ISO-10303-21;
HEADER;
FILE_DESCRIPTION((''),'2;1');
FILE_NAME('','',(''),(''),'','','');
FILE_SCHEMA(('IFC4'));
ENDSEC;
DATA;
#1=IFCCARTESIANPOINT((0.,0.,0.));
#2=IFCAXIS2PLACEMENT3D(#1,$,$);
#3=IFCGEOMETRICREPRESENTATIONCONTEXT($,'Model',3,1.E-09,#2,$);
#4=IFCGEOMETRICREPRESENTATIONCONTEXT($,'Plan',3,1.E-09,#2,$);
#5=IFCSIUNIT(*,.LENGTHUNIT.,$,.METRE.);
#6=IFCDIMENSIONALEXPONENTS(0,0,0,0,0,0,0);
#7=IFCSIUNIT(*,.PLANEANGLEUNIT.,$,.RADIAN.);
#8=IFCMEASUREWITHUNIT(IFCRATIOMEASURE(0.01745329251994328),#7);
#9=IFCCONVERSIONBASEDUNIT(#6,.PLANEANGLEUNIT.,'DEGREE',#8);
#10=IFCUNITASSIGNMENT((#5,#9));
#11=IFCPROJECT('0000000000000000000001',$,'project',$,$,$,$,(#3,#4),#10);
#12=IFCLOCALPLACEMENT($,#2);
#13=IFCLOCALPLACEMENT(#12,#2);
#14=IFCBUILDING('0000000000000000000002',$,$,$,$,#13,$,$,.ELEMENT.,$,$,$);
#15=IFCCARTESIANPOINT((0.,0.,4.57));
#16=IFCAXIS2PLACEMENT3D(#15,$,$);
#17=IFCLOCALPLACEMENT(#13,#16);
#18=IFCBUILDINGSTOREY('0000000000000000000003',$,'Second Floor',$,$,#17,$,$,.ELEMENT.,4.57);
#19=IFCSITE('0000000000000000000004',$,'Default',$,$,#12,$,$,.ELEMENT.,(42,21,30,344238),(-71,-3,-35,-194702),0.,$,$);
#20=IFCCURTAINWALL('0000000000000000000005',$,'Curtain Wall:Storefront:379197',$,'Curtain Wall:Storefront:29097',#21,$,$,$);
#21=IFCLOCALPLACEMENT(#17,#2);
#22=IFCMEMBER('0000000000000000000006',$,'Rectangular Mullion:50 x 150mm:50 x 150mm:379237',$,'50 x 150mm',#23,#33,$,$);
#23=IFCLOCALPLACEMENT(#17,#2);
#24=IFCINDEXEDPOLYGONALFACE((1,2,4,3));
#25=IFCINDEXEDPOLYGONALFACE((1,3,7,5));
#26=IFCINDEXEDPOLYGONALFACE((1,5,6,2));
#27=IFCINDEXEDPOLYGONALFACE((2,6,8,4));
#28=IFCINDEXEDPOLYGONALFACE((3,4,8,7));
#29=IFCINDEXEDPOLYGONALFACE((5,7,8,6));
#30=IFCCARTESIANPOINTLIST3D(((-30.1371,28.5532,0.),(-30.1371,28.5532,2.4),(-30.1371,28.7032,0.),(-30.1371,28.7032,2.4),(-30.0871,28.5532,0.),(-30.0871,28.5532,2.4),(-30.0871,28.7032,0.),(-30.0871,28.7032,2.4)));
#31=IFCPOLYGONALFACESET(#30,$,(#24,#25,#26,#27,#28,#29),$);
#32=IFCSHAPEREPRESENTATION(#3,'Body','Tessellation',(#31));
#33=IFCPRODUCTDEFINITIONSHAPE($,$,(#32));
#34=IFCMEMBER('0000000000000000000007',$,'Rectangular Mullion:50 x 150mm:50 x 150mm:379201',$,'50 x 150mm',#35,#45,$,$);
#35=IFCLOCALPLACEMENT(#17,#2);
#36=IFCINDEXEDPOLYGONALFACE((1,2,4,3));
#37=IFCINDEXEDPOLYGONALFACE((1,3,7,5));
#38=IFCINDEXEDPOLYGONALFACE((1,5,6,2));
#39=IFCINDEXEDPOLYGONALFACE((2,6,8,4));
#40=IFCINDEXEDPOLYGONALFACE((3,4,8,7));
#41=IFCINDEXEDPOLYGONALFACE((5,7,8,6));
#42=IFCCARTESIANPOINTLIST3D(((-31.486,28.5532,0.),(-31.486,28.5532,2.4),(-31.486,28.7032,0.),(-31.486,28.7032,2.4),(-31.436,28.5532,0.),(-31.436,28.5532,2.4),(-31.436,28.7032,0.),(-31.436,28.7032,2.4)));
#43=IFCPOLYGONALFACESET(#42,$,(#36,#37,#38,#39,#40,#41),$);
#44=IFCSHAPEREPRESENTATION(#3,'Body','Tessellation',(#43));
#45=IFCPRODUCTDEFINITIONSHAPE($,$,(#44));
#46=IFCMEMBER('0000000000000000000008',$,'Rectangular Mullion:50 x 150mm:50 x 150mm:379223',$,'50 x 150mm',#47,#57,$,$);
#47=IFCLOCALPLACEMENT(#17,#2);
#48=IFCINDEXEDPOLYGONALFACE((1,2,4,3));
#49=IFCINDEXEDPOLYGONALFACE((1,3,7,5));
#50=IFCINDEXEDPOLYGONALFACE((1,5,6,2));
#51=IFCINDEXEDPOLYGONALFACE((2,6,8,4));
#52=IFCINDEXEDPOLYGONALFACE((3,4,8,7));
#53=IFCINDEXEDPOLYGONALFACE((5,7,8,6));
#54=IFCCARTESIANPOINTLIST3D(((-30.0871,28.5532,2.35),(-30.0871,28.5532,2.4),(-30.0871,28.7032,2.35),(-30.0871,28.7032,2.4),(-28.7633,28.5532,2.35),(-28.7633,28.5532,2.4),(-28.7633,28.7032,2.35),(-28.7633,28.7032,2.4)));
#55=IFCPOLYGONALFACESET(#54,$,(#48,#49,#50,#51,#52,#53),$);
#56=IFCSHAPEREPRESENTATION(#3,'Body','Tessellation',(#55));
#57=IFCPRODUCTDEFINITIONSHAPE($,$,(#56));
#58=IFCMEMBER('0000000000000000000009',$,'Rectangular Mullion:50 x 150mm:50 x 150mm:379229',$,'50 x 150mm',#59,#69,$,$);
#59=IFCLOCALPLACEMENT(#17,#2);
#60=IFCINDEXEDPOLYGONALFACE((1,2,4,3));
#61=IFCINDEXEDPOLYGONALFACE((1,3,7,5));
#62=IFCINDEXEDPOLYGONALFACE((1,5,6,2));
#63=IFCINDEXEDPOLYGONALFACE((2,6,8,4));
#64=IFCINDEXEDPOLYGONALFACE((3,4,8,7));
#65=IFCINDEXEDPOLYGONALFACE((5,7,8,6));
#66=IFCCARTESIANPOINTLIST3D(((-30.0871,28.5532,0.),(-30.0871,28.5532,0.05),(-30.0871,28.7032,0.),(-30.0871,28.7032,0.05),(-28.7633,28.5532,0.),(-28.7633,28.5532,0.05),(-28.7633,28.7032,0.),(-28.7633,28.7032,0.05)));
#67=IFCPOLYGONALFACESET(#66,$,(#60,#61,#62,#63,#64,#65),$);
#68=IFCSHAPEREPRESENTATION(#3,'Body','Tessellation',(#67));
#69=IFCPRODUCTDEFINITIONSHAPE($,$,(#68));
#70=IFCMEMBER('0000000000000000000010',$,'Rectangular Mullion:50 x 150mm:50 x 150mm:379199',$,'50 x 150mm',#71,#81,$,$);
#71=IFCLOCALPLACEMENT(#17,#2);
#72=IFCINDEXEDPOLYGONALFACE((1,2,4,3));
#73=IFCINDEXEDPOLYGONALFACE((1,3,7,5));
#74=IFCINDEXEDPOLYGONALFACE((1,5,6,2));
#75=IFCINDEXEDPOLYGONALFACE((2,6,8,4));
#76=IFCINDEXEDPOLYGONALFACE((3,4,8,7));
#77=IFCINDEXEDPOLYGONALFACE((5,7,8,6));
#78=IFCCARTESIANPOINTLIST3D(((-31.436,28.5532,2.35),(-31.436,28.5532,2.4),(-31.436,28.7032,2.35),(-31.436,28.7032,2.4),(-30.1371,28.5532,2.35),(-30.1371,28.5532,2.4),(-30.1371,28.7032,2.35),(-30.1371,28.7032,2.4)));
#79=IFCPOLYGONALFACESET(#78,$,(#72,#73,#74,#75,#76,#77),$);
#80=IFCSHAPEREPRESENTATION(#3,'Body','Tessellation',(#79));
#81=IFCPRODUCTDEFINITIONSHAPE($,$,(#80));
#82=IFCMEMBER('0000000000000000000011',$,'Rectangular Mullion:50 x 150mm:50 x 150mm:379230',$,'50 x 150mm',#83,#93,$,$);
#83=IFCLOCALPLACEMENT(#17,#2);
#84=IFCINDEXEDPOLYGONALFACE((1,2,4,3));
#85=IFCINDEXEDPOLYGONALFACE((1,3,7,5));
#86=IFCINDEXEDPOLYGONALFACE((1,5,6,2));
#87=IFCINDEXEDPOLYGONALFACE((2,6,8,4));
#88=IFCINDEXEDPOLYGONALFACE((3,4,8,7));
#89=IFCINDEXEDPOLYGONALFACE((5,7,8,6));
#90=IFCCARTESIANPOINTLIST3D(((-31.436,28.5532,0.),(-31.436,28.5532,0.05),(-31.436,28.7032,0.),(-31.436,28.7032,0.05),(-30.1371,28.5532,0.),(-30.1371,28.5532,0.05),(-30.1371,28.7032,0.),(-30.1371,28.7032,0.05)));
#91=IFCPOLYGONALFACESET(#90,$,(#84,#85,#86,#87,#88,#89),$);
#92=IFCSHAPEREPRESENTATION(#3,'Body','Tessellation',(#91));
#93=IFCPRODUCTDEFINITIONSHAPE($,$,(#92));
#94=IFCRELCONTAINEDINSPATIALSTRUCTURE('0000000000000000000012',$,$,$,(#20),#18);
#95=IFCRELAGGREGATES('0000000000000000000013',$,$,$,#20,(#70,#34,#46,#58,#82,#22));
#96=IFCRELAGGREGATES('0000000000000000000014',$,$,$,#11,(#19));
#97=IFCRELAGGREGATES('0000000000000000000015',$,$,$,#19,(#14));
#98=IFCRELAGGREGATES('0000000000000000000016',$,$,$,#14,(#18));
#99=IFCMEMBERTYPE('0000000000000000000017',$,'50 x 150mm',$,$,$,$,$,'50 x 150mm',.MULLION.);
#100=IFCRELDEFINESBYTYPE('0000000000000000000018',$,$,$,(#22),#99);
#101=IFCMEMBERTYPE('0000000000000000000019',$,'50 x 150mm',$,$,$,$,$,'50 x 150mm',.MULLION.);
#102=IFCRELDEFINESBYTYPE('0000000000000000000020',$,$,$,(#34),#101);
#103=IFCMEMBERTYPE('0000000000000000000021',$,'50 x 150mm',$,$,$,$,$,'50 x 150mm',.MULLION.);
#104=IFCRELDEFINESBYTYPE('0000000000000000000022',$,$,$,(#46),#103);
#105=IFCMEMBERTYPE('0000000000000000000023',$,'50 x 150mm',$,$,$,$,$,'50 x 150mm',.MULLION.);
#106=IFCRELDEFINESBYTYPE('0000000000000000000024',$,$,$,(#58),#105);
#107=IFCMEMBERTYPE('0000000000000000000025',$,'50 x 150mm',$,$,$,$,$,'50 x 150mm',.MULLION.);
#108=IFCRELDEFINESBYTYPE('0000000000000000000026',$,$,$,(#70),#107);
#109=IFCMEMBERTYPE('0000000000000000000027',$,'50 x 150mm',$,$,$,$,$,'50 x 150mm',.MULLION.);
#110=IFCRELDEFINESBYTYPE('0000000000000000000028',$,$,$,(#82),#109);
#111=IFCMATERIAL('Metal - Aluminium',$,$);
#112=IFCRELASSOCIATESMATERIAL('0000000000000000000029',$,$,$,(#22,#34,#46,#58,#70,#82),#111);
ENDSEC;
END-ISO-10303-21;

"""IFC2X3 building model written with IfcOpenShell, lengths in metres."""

from ifc_helpers import new_model, entity, si_unit, converted_unit, frame, origin, origin_2d_with_axis, place, context, project, spatial, rectangle, extrude, source, transform, mapped, material, type_object, type_shapes, element, aggregate, save


model = new_model("IFC2X3")

# Units and contexts
model_context = context("Model", 3, precision=1e-09, world=origin())
plan_context = context("Plan", 3, precision=1e-09, world=origin())
ifc_project = project(units=[si_unit("LENGTHUNIT", "METRE"), converted_unit("PLANEANGLEUNIT", "DEGREE", entity("IfcRatioMeasure", 0.01745329251994328), si_unit("PLANEANGLEUNIT", "RADIAN"), dimensions=[0, 0, 0, 0, 0, 0, 0])], contexts=[model_context, plan_context])

# Site, building, storey
site_placement = place(None, origin())
site = spatial("IfcSite", under=ifc_project, at=site_placement, Name="Default", CompositionType="ELEMENT", RefLatitude=(42, 21, 30, 344238), RefLongitude=(-71, -3, -35, -194702), RefElevation=0.0)
building_placement = place(site_placement, origin())
building = spatial("IfcBuilding", under=site, at=building_placement, CompositionType="ELEMENT")
storey_placement = place(building_placement, frame((0.0, 0.0, 4.57)))
storey = spatial("IfcBuildingStorey", under=building, at=storey_placement, Name="Second Floor", CompositionType="ELEMENT", Elevation=4.57)

# Curtain wall, members
curtain_wall_placement = place(storey_placement, origin())
curtain_wall = element("IfcCurtainWall", 1, at=curtain_wall_placement, inside=storey, Name="Curtain Wall:Storefront:379197", ObjectType="Curtain Wall:Storefront:29097")
ifc_material_1 = material(Name="Metal - Aluminium")
member_type_1 = type_object("IfcMemberType", Name="50 x 150mm", ElementType="50 x 150mm", PredefinedType="MULLION")
shared_shape_1 = source(origin(), model_context, "Body", "SweptSolid", [
    extrude(rectangle(XDim=0.05, YDim=0.15, at=origin_2d_with_axis()), frame((0.0, 0.0, -2.4), z_axis=(0.0, 0.0, 1.0), x_axis=(-1.0, 0.0, 0.0)), (0.0, 0.0, 1.0), 2.4),
])
type_shapes(member_type_1, [shared_shape_1])
member_1_placement = place(storey_placement, frame((-30.1121, 28.6282, 0.0), z_axis=(0.0, 0.0, -1.0), x_axis=(-1.0, 0.0, 0.0)))
member_1 = element("IfcMember", 2, at=member_1_placement, type_object=member_type_1, material=ifc_material_1, Name="Rectangular Mullion:50 x 150mm:50 x 150mm:379237", ObjectType="50 x 150mm", context=model_context, shape_type="MappedRepresentation", body=[
    mapped(shared_shape_1, transform((0.0, 0.0, 0.0), scale=1.0)),
])
member_type_2 = type_object("IfcMemberType", Name="50 x 150mm", ElementType="50 x 150mm", PredefinedType="MULLION")
shared_shape_2 = source(origin(), model_context, "Body", "SweptSolid", [
    extrude(rectangle(XDim=0.05, YDim=0.15, at=origin_2d_with_axis()), frame((-0.025, 0.0, -2.4), z_axis=(0.0, 0.0, 1.0), x_axis=(-1.0, 0.0, 0.0)), (0.0, 0.0, 1.0), 2.4),
])
type_shapes(member_type_2, [shared_shape_2])
member_2_placement = place(storey_placement, frame((-31.486, 28.6282, 0.0), z_axis=(0.0, 0.0, -1.0), x_axis=(-1.0, 0.0, 0.0)))
member_2 = element("IfcMember", 3, at=member_2_placement, type_object=member_type_2, material=ifc_material_1, Name="Rectangular Mullion:50 x 150mm:50 x 150mm:379201", ObjectType="50 x 150mm", context=model_context, shape_type="MappedRepresentation", body=[
    mapped(shared_shape_2, transform((0.0, 0.0, 0.0), scale=1.0)),
])
member_type_3 = type_object("IfcMemberType", Name="50 x 150mm", ElementType="50 x 150mm", PredefinedType="MULLION")
shared_shape_3 = source(origin(), model_context, "Body", "SweptSolid", [
    extrude(rectangle(XDim=0.05, YDim=0.15, at=origin_2d_with_axis()), frame((-0.025, 0.0, -1.3239), z_axis=(0.0, 0.0, 1.0), x_axis=(-1.0, 0.0, 0.0)), (0.0, 0.0, 1.0), 1.3239),
])
type_shapes(member_type_3, [shared_shape_3])
member_3_placement = place(storey_placement, frame((-30.0871, 28.6282, 2.4), z_axis=(-1.0, 0.0, 0.0), x_axis=(0.0, 0.0, 1.0)))
member_3 = element("IfcMember", 4, at=member_3_placement, type_object=member_type_3, material=ifc_material_1, Name="Rectangular Mullion:50 x 150mm:50 x 150mm:379223", ObjectType="50 x 150mm", context=model_context, shape_type="MappedRepresentation", body=[
    mapped(shared_shape_3, transform((0.0, 0.0, 0.0), scale=1.0)),
])
member_type_4 = type_object("IfcMemberType", Name="50 x 150mm", ElementType="50 x 150mm", PredefinedType="MULLION")
shared_shape_4 = source(origin(), model_context, "Body", "SweptSolid", [
    extrude(rectangle(XDim=0.05, YDim=0.15, at=origin_2d_with_axis()), frame((-0.025, 0.0, -1.3239), z_axis=(0.0, 0.0, 1.0), x_axis=(-1.0, 0.0, 0.0)), (0.0, 0.0, 1.0), 1.3239),
])
type_shapes(member_type_4, [shared_shape_4])
member_4_placement = place(storey_placement, frame((-28.7633, 28.6282, 0.0), z_axis=(1.0, 0.0, 0.0), x_axis=(0.0, 0.0, -1.0)))
member_4 = element("IfcMember", 5, at=member_4_placement, type_object=member_type_4, material=ifc_material_1, Name="Rectangular Mullion:50 x 150mm:50 x 150mm:379229", ObjectType="50 x 150mm", context=model_context, shape_type="MappedRepresentation", body=[
    mapped(shared_shape_4, transform((0.0, 0.0, 0.0), scale=1.0)),
])
member_type_5 = type_object("IfcMemberType", Name="50 x 150mm", ElementType="50 x 150mm", PredefinedType="MULLION")
shared_shape_5 = source(origin(), model_context, "Body", "SweptSolid", [
    extrude(rectangle(XDim=0.05, YDim=0.15, at=origin_2d_with_axis()), frame((-0.025, 0.0, -1.2989), z_axis=(0.0, 0.0, 1.0), x_axis=(-1.0, 0.0, 0.0)), (0.0, 0.0, 1.0), 1.2989),
])
type_shapes(member_type_5, [shared_shape_5])
member_5_placement = place(storey_placement, frame((-31.436, 28.6282, 2.4), z_axis=(-1.0, 0.0, 0.0), x_axis=(0.0, 0.0, 1.0)))
member_5 = element("IfcMember", 6, at=member_5_placement, type_object=member_type_5, material=ifc_material_1, Name="Rectangular Mullion:50 x 150mm:50 x 150mm:379199", ObjectType="50 x 150mm", context=model_context, shape_type="MappedRepresentation", body=[
    mapped(shared_shape_5, transform((0.0, 0.0, 0.0), scale=1.0)),
])
member_type_6 = type_object("IfcMemberType", Name="50 x 150mm", ElementType="50 x 150mm", PredefinedType="MULLION")
shared_shape_6 = source(origin(), model_context, "Body", "SweptSolid", [
    extrude(rectangle(XDim=0.05, YDim=0.15, at=origin_2d_with_axis()), frame((-0.025, 0.0, -1.2989), z_axis=(0.0, 0.0, 1.0), x_axis=(-1.0, 0.0, 0.0)), (0.0, 0.0, 1.0), 1.2989),
])
type_shapes(member_type_6, [shared_shape_6])
member_6_placement = place(storey_placement, frame((-30.1371, 28.6282, 0.0), z_axis=(1.0, 0.0, 0.0), x_axis=(0.0, 0.0, -1.0)))
member_6 = element("IfcMember", 7, at=member_6_placement, type_object=member_type_6, material=ifc_material_1, Name="Rectangular Mullion:50 x 150mm:50 x 150mm:379230", ObjectType="50 x 150mm", context=model_context, shape_type="MappedRepresentation", body=[
    mapped(shared_shape_6, transform((0.0, 0.0, 0.0), scale=1.0)),
])
aggregate(curtain_wall, [member_5, member_2, member_3, member_4, member_6, member_1])

save(model, "model.ifc")
